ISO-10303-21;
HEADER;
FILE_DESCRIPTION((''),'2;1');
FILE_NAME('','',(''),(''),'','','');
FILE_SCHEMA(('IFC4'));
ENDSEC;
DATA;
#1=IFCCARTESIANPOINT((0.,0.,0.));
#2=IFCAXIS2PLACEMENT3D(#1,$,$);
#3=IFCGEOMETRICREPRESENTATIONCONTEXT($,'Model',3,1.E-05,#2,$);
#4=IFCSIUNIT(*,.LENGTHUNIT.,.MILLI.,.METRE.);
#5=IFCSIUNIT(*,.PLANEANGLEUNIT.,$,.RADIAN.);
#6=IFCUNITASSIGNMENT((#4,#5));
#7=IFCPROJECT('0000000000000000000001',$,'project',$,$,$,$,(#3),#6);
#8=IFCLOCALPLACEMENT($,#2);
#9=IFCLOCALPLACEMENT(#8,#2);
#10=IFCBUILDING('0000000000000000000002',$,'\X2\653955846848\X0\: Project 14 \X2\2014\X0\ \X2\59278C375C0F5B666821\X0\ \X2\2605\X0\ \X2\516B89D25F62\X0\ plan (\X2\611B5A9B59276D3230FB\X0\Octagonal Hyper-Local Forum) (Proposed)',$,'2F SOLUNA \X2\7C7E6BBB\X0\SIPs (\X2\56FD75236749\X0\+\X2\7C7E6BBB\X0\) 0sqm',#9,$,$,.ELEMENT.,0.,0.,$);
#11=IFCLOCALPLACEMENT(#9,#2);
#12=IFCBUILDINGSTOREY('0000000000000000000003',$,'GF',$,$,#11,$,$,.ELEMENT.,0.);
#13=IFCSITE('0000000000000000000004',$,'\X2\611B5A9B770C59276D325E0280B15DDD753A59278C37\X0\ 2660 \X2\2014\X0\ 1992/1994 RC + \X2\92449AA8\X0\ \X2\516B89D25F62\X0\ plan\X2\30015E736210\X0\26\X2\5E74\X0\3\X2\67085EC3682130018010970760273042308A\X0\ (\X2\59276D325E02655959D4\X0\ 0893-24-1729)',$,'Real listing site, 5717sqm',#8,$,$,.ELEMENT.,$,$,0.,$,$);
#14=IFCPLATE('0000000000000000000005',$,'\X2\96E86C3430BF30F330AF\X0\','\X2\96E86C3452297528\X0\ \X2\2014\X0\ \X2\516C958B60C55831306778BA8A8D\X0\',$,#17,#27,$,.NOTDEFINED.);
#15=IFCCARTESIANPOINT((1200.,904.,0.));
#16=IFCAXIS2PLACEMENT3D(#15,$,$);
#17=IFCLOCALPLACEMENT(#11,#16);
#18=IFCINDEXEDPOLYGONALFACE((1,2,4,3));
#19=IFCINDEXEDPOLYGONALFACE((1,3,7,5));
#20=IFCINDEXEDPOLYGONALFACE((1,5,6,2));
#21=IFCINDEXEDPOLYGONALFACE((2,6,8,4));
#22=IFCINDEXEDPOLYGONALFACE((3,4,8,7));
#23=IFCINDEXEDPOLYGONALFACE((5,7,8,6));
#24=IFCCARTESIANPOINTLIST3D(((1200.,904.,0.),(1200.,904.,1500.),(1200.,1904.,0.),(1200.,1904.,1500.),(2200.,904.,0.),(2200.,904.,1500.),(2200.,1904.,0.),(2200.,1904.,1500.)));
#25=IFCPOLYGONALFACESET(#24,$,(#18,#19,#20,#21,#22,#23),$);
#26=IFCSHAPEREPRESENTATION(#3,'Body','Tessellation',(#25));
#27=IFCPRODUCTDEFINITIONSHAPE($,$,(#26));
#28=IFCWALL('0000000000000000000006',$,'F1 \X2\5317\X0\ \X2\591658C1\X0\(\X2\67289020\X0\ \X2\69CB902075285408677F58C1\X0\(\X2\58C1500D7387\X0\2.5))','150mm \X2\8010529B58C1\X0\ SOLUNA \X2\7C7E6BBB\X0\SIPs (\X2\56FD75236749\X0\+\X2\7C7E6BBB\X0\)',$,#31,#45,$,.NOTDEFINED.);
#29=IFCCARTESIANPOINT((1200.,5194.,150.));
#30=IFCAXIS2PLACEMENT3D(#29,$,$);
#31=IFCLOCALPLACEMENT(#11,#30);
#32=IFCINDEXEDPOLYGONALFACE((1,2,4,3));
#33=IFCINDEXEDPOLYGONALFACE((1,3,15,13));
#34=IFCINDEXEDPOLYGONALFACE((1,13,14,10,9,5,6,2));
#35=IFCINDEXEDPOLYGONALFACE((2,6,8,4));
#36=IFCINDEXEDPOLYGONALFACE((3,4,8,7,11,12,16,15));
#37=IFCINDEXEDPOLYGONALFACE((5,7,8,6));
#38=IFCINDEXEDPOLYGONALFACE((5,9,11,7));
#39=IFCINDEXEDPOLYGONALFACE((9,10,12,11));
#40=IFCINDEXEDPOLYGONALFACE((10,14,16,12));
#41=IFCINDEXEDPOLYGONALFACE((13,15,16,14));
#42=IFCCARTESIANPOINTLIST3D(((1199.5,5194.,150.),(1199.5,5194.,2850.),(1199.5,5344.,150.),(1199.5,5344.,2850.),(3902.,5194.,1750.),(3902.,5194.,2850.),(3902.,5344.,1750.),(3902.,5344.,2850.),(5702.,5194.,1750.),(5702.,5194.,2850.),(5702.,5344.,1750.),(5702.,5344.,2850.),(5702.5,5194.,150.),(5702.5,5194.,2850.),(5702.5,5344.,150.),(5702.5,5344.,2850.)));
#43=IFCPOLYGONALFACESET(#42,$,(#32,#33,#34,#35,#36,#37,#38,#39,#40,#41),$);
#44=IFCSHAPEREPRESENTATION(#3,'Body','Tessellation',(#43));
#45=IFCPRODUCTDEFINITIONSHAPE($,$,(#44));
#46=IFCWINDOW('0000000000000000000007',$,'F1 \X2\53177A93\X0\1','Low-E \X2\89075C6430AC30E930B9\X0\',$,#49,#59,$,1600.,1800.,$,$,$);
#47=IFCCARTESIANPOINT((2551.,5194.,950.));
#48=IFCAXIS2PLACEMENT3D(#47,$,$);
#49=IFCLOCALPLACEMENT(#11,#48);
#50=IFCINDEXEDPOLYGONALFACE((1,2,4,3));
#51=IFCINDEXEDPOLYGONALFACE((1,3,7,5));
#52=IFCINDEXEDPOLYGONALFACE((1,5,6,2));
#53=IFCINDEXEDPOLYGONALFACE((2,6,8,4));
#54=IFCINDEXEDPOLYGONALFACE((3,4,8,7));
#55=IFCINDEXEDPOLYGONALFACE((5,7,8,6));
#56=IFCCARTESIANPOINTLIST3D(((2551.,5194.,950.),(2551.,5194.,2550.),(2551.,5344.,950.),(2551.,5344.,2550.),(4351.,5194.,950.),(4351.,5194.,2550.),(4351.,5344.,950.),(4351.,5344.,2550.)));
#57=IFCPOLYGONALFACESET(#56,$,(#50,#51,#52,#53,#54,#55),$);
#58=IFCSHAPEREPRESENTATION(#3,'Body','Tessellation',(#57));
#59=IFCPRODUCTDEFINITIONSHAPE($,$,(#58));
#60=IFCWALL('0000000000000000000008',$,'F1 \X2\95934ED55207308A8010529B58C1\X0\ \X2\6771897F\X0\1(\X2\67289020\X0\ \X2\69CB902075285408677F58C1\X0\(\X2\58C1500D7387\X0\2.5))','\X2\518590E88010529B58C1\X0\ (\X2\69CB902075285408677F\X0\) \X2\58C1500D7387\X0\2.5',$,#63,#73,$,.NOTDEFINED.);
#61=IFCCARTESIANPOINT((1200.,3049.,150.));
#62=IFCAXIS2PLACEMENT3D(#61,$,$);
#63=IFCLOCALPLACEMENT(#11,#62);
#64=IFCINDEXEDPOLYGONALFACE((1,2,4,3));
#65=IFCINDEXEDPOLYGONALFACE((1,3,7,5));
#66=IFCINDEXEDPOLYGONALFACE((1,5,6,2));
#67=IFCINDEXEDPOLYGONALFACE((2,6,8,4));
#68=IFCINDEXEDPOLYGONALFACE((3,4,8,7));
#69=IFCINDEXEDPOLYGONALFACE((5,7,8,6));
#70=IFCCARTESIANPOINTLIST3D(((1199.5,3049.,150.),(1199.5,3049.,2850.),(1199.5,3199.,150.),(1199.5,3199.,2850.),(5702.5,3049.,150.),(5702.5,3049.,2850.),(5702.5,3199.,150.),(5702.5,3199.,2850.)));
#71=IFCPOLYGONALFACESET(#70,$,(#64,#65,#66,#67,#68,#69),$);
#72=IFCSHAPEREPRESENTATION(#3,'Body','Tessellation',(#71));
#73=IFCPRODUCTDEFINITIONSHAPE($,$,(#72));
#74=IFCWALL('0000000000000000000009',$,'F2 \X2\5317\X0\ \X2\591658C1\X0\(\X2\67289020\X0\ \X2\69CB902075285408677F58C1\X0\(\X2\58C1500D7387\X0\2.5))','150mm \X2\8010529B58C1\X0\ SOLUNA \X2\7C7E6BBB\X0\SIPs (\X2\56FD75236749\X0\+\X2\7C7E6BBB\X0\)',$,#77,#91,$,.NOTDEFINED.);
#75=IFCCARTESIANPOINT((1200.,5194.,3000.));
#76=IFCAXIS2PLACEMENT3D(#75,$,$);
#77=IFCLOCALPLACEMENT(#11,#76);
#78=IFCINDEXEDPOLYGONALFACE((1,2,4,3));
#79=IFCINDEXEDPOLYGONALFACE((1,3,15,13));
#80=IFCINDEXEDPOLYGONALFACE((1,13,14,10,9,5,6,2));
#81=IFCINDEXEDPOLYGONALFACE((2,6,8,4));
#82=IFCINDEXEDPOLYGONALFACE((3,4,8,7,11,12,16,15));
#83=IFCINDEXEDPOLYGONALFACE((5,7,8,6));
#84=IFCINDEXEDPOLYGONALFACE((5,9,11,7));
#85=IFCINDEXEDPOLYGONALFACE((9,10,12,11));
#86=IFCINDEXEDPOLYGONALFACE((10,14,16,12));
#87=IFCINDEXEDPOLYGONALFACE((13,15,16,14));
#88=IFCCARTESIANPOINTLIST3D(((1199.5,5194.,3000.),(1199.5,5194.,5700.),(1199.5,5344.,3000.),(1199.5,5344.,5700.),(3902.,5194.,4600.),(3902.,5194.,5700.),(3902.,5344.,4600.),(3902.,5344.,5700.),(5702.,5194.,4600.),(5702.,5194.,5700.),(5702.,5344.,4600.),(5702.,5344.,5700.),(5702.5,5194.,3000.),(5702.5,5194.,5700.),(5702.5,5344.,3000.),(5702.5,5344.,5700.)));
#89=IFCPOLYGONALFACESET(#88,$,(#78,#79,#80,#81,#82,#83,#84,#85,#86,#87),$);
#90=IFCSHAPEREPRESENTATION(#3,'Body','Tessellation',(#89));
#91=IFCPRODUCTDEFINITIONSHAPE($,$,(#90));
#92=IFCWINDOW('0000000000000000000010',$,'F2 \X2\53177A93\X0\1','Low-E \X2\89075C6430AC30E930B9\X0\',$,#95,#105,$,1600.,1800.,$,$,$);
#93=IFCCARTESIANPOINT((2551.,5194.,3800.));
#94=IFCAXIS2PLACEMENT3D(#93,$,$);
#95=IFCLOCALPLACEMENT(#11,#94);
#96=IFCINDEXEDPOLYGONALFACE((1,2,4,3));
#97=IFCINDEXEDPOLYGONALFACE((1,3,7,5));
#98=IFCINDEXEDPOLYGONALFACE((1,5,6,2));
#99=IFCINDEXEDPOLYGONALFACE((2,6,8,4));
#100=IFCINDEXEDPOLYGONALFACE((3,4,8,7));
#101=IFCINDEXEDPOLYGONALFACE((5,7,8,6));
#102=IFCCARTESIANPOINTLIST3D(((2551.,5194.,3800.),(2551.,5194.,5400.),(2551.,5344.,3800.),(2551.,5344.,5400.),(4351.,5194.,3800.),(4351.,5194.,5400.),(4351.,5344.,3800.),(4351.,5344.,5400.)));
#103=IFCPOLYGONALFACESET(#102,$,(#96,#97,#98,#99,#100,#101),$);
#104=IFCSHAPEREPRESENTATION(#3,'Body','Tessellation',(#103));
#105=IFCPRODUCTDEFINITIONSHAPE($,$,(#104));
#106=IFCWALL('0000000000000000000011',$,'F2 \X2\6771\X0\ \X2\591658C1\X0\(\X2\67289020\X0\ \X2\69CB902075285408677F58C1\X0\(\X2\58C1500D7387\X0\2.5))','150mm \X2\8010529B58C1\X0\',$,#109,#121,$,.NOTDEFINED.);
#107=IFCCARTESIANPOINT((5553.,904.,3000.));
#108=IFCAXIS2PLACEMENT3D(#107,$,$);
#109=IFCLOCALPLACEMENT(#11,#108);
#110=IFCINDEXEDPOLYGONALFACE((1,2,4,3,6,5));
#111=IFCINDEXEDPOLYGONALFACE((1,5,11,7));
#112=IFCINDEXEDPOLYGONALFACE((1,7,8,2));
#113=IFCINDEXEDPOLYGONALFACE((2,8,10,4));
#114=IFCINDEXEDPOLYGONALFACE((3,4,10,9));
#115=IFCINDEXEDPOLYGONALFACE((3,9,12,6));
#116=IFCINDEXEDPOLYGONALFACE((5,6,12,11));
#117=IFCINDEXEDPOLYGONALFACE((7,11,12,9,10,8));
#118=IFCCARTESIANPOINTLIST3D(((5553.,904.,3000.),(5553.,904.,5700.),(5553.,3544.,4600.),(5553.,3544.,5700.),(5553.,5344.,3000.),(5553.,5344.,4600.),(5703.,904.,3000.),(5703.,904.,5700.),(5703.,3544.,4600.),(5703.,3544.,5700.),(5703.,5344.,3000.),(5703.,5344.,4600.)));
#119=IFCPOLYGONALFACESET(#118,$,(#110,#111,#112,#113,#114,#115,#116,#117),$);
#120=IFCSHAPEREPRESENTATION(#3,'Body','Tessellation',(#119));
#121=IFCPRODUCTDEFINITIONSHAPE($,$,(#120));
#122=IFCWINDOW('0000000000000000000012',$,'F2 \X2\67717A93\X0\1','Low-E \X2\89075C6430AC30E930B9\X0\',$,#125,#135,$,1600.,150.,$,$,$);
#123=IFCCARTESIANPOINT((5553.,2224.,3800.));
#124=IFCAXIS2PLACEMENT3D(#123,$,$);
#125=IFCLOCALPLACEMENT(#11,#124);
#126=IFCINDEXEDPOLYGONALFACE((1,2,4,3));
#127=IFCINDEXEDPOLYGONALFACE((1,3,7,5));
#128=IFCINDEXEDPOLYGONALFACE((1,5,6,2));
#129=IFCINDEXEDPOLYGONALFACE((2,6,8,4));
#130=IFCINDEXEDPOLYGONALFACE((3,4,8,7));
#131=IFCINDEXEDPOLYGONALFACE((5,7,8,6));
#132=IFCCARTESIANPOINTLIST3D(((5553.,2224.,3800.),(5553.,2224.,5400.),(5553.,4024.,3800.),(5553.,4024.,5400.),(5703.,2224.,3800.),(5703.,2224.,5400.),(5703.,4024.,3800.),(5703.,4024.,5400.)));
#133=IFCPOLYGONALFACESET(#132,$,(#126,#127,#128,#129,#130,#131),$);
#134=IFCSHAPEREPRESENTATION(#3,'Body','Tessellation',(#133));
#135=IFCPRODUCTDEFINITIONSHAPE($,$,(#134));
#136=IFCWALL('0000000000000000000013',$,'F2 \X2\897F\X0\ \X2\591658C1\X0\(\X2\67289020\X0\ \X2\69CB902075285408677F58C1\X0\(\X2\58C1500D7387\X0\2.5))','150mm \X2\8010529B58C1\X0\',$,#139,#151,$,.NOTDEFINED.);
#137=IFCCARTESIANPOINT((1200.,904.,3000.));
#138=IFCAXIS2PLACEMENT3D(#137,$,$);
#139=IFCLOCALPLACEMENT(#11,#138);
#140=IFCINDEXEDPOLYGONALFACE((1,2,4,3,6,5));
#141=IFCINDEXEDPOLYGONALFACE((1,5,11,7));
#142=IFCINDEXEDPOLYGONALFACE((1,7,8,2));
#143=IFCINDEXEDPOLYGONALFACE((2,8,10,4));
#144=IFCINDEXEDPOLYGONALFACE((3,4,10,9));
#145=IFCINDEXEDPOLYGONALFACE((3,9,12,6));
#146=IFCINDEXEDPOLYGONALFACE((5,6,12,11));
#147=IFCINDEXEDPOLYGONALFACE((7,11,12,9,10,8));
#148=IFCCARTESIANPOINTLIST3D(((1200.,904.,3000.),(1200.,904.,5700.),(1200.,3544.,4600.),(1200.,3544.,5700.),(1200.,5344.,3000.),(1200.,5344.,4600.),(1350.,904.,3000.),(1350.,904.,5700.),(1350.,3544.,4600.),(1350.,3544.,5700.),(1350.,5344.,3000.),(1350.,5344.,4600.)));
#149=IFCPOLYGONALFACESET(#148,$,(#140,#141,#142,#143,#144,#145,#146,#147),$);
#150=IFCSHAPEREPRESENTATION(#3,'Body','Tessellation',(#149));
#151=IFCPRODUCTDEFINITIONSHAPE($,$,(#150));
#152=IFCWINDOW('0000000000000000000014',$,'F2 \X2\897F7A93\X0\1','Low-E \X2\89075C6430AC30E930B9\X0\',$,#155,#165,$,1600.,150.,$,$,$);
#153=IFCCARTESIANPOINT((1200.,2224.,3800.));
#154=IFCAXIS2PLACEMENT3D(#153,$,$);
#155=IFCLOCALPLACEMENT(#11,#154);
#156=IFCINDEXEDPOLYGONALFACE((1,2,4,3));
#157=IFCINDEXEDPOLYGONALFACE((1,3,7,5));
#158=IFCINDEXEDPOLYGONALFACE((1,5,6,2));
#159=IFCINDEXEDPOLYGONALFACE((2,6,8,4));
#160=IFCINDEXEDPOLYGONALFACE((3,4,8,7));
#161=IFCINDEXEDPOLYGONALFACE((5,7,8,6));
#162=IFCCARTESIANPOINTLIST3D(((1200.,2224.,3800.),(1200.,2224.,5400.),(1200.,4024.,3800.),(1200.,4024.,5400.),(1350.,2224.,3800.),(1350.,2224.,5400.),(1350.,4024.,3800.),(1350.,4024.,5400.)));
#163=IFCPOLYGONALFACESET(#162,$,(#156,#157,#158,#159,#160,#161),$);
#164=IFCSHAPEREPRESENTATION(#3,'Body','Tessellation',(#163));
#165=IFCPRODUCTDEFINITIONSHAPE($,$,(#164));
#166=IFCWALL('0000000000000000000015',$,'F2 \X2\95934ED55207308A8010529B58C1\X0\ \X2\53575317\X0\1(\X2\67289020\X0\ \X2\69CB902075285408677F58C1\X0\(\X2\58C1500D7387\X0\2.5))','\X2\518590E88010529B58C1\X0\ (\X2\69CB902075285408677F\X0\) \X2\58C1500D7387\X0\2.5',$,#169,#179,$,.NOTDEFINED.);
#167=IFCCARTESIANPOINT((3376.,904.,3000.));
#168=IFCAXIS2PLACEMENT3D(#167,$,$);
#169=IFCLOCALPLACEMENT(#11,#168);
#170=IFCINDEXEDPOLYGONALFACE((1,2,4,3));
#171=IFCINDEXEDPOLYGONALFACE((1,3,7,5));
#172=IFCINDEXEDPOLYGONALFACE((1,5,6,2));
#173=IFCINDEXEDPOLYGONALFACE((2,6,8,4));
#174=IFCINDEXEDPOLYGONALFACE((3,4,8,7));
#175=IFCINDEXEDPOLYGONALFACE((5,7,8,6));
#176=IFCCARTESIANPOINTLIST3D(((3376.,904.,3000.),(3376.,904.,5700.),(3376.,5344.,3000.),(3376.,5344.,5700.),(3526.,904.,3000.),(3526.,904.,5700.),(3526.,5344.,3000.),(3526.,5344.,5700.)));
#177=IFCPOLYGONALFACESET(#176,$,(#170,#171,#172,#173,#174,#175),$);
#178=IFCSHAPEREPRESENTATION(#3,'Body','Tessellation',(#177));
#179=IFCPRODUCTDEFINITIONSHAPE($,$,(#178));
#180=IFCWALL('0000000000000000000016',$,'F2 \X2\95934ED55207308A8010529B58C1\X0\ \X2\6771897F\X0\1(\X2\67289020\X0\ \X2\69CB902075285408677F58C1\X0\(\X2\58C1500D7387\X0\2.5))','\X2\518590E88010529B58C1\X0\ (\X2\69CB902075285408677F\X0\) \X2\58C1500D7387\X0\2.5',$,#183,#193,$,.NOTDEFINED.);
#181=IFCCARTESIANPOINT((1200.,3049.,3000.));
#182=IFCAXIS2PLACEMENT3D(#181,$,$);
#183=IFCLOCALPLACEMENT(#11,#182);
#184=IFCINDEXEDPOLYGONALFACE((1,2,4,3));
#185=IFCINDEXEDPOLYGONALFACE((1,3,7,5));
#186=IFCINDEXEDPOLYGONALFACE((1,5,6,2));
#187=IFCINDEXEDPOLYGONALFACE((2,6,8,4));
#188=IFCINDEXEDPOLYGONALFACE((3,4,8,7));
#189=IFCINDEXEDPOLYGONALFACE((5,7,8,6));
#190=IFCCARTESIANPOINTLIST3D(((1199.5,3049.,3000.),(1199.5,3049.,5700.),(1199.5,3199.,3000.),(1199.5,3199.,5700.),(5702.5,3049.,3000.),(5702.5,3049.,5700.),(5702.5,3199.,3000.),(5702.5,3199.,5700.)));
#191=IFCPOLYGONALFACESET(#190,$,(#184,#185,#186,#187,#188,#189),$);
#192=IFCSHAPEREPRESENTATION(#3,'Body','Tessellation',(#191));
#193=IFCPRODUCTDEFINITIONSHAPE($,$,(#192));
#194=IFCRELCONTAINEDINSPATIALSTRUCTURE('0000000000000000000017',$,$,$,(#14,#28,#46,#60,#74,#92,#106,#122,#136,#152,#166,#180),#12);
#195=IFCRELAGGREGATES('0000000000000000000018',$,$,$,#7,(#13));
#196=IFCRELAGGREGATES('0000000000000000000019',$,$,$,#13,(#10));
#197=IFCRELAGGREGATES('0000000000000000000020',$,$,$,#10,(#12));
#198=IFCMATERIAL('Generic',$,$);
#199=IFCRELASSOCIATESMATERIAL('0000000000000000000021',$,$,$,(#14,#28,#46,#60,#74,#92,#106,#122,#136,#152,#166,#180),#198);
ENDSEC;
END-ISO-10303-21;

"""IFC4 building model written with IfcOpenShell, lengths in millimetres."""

from ifc_helpers import new_model, si_unit, frame, frame_2d, origin, place, context, project, spatial, rectangle, extrude, material, element, fill, save


model = new_model("IFC4")

# Units and contexts
model_context = context("Model", 3, precision=1e-05, world=origin())
ifc_project = project(units=[si_unit("LENGTHUNIT", "METRE", prefix="MILLI"), si_unit("PLANEANGLEUNIT", "RADIAN")], contexts=[model_context])

# Site, building, storey
site_placement = place(None, origin())
site = spatial("IfcSite", under=ifc_project, at=site_placement, Name="愛媛県大洲市肱川町大谷 2660 — 1992/1994 RC + 鉄骨 八角形 plan、平成26年3月廃校、耐震性あり (大洲市教委 0893-24-1729)", ObjectType="Real listing site, 5717sqm", CompositionType="ELEMENT", RefElevation=0.0)
building_placement = place(site_placement, origin())
building = spatial("IfcBuilding", under=site, at=building_placement, Name="改善案: Project 14 — 大谷小学校 ★ 八角形 plan (愛媛大洲・Octagonal Hyper-Local Forum) (Proposed)", ObjectType="2F SOLUNA 籾殻SIPs (国産杉+籾殻) 0sqm", CompositionType="ELEMENT", ElevationOfRefHeight=0.0, ElevationOfTerrain=0.0)
storey_placement = place(building_placement, origin())
storey = spatial("IfcBuildingStorey", under=building, at=storey_placement, Name="GF", CompositionType="ELEMENT", Elevation=0.0)

# Plate
ifc_material_1 = material(Name="Generic")
plate_placement = place(storey_placement, frame((1200.0, 904.0, 0.0)))
element("IfcPlate", 1, at=plate_placement, inside=storey, material=ifc_material_1, Name="雨水タンク", Description="雨水利用 — 公開情報で確認", PredefinedType="NOTDEFINED", context=model_context, shape_type="SweptSolid", body=[
    extrude(rectangle(XDim=1000.0, YDim=1000.0, at=frame_2d((500.0, 500.0))), frame((1200.0, 904.0, 0.0)), (0.0, 0.0, 1.0), 1500.0),
])

# Wall, opening, window
wall_1_placement = place(storey_placement, frame((1200.0, 5194.0, 150.0)))
wall_1 = element("IfcWall", 2, at=wall_1_placement, inside=storey, material=ifc_material_1, Name="F1 北 外壁(木造 構造用合板壁(壁倍率2.5))", Description="150mm 耐力壁 SOLUNA 籾殻SIPs (国産杉+籾殻)", PredefinedType="NOTDEFINED", context=model_context, shape_type="SweptSolid", body=[
    extrude(rectangle(XDim=4503.0, YDim=150.0, at=frame_2d((2251.0, 75.0))), frame((1200.0, 5194.0, 150.0)), (0.0, 0.0, 1.0), 2700.0),
])
opening_1_placement = place(storey_placement, frame((2551.0, 5194.0, 950.0)))
opening_1 = element("IfcOpeningElement", 3, at=opening_1_placement, cuts=wall_1, PredefinedType="NOTDEFINED", context=model_context, shape_type="SweptSolid", body=[
    extrude(rectangle(XDim=1800.0, YDim=150.0, at=frame_2d((900.0, 75.0))), frame((2551.0, 5194.0, 950.0)), (0.0, 0.0, 1.0), 1600.0),
])
window_1_placement = place(storey_placement, frame((2551.0, 5194.0, 950.0)))
window_1 = element("IfcWindow", 4, at=window_1_placement, inside=storey, material=ifc_material_1, Name="F1 北窓1", Description="Low-E 複層ガラス", OverallHeight=1600.0, OverallWidth=1800.0, context=model_context, shape_type="SweptSolid", body=[
    extrude(rectangle(XDim=1800.0, YDim=150.0, at=frame_2d((900.0, 75.0))), frame((2551.0, 5194.0, 950.0)), (0.0, 0.0, 1.0), 1600.0),
])
fill(opening_1, window_1)

# Wall
wall_2_placement = place(storey_placement, frame((1200.0, 3049.0, 150.0)))
element("IfcWall", 5, at=wall_2_placement, inside=storey, material=ifc_material_1, Name="F1 間仕切り耐力壁 東西1(木造 構造用合板壁(壁倍率2.5))", Description="内部耐力壁 (構造用合板) 壁倍率2.5", PredefinedType="NOTDEFINED", context=model_context, shape_type="SweptSolid", body=[
    extrude(rectangle(XDim=4503.0, YDim=150.0, at=frame_2d((2251.0, 75.0))), frame((1200.0, 3049.0, 150.0)), (0.0, 0.0, 1.0), 2700.0),
])

# Walls, openings, windows
wall_3_placement = place(storey_placement, frame((1200.0, 5194.0, 3000.0)))
wall_3 = element("IfcWall", 6, at=wall_3_placement, inside=storey, material=ifc_material_1, Name="F2 北 外壁(木造 構造用合板壁(壁倍率2.5))", Description="150mm 耐力壁 SOLUNA 籾殻SIPs (国産杉+籾殻)", PredefinedType="NOTDEFINED", context=model_context, shape_type="SweptSolid", body=[
    extrude(rectangle(XDim=4503.0, YDim=150.0, at=frame_2d((2251.0, 75.0))), frame((1200.0, 5194.0, 3000.0)), (0.0, 0.0, 1.0), 2700.0),
])
opening_2_placement = place(storey_placement, frame((2551.0, 5194.0, 3800.0)))
opening_2 = element("IfcOpeningElement", 7, at=opening_2_placement, cuts=wall_3, PredefinedType="NOTDEFINED", context=model_context, shape_type="SweptSolid", body=[
    extrude(rectangle(XDim=1800.0, YDim=150.0, at=frame_2d((900.0, 75.0))), frame((2551.0, 5194.0, 3800.0)), (0.0, 0.0, 1.0), 1600.0),
])
window_2_placement = place(storey_placement, frame((2551.0, 5194.0, 3800.0)))
window_2 = element("IfcWindow", 8, at=window_2_placement, inside=storey, material=ifc_material_1, Name="F2 北窓1", Description="Low-E 複層ガラス", OverallHeight=1600.0, OverallWidth=1800.0, context=model_context, shape_type="SweptSolid", body=[
    extrude(rectangle(XDim=1800.0, YDim=150.0, at=frame_2d((900.0, 75.0))), frame((2551.0, 5194.0, 3800.0)), (0.0, 0.0, 1.0), 1600.0),
])
fill(opening_2, window_2)
wall_4_placement = place(storey_placement, frame((5553.0, 904.0, 3000.0)))
wall_4 = element("IfcWall", 9, at=wall_4_placement, inside=storey, material=ifc_material_1, Name="F2 東 外壁(木造 構造用合板壁(壁倍率2.5))", Description="150mm 耐力壁", PredefinedType="NOTDEFINED", context=model_context, shape_type="SweptSolid", body=[
    extrude(rectangle(XDim=150.0, YDim=4440.0, at=frame_2d((75.0, 2220.0))), frame((5553.0, 904.0, 3000.0)), (0.0, 0.0, 1.0), 2700.0),
])
opening_3_placement = place(storey_placement, frame((5553.0, 2224.0, 3800.0)))
opening_3 = element("IfcOpeningElement", 10, at=opening_3_placement, cuts=wall_4, PredefinedType="NOTDEFINED", context=model_context, shape_type="SweptSolid", body=[
    extrude(rectangle(XDim=150.0, YDim=1800.0, at=frame_2d((75.0, 900.0))), frame((5553.0, 2224.0, 3800.0)), (0.0, 0.0, 1.0), 1600.0),
])
window_3_placement = place(storey_placement, frame((5553.0, 2224.0, 3800.0)))
window_3 = element("IfcWindow", 11, at=window_3_placement, inside=storey, material=ifc_material_1, Name="F2 東窓1", Description="Low-E 複層ガラス", OverallHeight=1600.0, OverallWidth=150.0, context=model_context, shape_type="SweptSolid", body=[
    extrude(rectangle(XDim=150.0, YDim=1800.0, at=frame_2d((75.0, 900.0))), frame((5553.0, 2224.0, 3800.0)), (0.0, 0.0, 1.0), 1600.0),
])
fill(opening_3, window_3)
wall_5_placement = place(storey_placement, frame((1200.0, 904.0, 3000.0)))
wall_5 = element("IfcWall", 12, at=wall_5_placement, inside=storey, material=ifc_material_1, Name="F2 西 外壁(木造 構造用合板壁(壁倍率2.5))", Description="150mm 耐力壁", PredefinedType="NOTDEFINED", context=model_context, shape_type="SweptSolid", body=[
    extrude(rectangle(XDim=150.0, YDim=4440.0, at=frame_2d((75.0, 2220.0))), frame((1200.0, 904.0, 3000.0)), (0.0, 0.0, 1.0), 2700.0),
])
opening_4_placement = place(storey_placement, frame((1200.0, 2224.0, 3800.0)))
opening_4 = element("IfcOpeningElement", 13, at=opening_4_placement, cuts=wall_5, PredefinedType="NOTDEFINED", context=model_context, shape_type="SweptSolid", body=[
    extrude(rectangle(XDim=150.0, YDim=1800.0, at=frame_2d((75.0, 900.0))), frame((1200.0, 2224.0, 3800.0)), (0.0, 0.0, 1.0), 1600.0),
])
window_4_placement = place(storey_placement, frame((1200.0, 2224.0, 3800.0)))
window_4 = element("IfcWindow", 14, at=window_4_placement, inside=storey, material=ifc_material_1, Name="F2 西窓1", Description="Low-E 複層ガラス", OverallHeight=1600.0, OverallWidth=150.0, context=model_context, shape_type="SweptSolid", body=[
    extrude(rectangle(XDim=150.0, YDim=1800.0, at=frame_2d((75.0, 900.0))), frame((1200.0, 2224.0, 3800.0)), (0.0, 0.0, 1.0), 1600.0),
])
fill(opening_4, window_4)

# Walls
wall_6_placement = place(storey_placement, frame((3376.0, 904.0, 3000.0)))
element("IfcWall", 15, at=wall_6_placement, inside=storey, material=ifc_material_1, Name="F2 間仕切り耐力壁 南北1(木造 構造用合板壁(壁倍率2.5))", Description="内部耐力壁 (構造用合板) 壁倍率2.5", PredefinedType="NOTDEFINED", context=model_context, shape_type="SweptSolid", body=[
    extrude(rectangle(XDim=150.0, YDim=4440.0, at=frame_2d((75.0, 2220.0))), frame((3376.0, 904.0, 3000.0)), (0.0, 0.0, 1.0), 2700.0),
])
wall_7_placement = place(storey_placement, frame((1200.0, 3049.0, 3000.0)))
element("IfcWall", 16, at=wall_7_placement, inside=storey, material=ifc_material_1, Name="F2 間仕切り耐力壁 東西1(木造 構造用合板壁(壁倍率2.5))", Description="内部耐力壁 (構造用合板) 壁倍率2.5", PredefinedType="NOTDEFINED", context=model_context, shape_type="SweptSolid", body=[
    extrude(rectangle(XDim=4503.0, YDim=150.0, at=frame_2d((2251.0, 75.0))), frame((1200.0, 3049.0, 3000.0)), (0.0, 0.0, 1.0), 2700.0),
])

save(model, "model.ifc")
